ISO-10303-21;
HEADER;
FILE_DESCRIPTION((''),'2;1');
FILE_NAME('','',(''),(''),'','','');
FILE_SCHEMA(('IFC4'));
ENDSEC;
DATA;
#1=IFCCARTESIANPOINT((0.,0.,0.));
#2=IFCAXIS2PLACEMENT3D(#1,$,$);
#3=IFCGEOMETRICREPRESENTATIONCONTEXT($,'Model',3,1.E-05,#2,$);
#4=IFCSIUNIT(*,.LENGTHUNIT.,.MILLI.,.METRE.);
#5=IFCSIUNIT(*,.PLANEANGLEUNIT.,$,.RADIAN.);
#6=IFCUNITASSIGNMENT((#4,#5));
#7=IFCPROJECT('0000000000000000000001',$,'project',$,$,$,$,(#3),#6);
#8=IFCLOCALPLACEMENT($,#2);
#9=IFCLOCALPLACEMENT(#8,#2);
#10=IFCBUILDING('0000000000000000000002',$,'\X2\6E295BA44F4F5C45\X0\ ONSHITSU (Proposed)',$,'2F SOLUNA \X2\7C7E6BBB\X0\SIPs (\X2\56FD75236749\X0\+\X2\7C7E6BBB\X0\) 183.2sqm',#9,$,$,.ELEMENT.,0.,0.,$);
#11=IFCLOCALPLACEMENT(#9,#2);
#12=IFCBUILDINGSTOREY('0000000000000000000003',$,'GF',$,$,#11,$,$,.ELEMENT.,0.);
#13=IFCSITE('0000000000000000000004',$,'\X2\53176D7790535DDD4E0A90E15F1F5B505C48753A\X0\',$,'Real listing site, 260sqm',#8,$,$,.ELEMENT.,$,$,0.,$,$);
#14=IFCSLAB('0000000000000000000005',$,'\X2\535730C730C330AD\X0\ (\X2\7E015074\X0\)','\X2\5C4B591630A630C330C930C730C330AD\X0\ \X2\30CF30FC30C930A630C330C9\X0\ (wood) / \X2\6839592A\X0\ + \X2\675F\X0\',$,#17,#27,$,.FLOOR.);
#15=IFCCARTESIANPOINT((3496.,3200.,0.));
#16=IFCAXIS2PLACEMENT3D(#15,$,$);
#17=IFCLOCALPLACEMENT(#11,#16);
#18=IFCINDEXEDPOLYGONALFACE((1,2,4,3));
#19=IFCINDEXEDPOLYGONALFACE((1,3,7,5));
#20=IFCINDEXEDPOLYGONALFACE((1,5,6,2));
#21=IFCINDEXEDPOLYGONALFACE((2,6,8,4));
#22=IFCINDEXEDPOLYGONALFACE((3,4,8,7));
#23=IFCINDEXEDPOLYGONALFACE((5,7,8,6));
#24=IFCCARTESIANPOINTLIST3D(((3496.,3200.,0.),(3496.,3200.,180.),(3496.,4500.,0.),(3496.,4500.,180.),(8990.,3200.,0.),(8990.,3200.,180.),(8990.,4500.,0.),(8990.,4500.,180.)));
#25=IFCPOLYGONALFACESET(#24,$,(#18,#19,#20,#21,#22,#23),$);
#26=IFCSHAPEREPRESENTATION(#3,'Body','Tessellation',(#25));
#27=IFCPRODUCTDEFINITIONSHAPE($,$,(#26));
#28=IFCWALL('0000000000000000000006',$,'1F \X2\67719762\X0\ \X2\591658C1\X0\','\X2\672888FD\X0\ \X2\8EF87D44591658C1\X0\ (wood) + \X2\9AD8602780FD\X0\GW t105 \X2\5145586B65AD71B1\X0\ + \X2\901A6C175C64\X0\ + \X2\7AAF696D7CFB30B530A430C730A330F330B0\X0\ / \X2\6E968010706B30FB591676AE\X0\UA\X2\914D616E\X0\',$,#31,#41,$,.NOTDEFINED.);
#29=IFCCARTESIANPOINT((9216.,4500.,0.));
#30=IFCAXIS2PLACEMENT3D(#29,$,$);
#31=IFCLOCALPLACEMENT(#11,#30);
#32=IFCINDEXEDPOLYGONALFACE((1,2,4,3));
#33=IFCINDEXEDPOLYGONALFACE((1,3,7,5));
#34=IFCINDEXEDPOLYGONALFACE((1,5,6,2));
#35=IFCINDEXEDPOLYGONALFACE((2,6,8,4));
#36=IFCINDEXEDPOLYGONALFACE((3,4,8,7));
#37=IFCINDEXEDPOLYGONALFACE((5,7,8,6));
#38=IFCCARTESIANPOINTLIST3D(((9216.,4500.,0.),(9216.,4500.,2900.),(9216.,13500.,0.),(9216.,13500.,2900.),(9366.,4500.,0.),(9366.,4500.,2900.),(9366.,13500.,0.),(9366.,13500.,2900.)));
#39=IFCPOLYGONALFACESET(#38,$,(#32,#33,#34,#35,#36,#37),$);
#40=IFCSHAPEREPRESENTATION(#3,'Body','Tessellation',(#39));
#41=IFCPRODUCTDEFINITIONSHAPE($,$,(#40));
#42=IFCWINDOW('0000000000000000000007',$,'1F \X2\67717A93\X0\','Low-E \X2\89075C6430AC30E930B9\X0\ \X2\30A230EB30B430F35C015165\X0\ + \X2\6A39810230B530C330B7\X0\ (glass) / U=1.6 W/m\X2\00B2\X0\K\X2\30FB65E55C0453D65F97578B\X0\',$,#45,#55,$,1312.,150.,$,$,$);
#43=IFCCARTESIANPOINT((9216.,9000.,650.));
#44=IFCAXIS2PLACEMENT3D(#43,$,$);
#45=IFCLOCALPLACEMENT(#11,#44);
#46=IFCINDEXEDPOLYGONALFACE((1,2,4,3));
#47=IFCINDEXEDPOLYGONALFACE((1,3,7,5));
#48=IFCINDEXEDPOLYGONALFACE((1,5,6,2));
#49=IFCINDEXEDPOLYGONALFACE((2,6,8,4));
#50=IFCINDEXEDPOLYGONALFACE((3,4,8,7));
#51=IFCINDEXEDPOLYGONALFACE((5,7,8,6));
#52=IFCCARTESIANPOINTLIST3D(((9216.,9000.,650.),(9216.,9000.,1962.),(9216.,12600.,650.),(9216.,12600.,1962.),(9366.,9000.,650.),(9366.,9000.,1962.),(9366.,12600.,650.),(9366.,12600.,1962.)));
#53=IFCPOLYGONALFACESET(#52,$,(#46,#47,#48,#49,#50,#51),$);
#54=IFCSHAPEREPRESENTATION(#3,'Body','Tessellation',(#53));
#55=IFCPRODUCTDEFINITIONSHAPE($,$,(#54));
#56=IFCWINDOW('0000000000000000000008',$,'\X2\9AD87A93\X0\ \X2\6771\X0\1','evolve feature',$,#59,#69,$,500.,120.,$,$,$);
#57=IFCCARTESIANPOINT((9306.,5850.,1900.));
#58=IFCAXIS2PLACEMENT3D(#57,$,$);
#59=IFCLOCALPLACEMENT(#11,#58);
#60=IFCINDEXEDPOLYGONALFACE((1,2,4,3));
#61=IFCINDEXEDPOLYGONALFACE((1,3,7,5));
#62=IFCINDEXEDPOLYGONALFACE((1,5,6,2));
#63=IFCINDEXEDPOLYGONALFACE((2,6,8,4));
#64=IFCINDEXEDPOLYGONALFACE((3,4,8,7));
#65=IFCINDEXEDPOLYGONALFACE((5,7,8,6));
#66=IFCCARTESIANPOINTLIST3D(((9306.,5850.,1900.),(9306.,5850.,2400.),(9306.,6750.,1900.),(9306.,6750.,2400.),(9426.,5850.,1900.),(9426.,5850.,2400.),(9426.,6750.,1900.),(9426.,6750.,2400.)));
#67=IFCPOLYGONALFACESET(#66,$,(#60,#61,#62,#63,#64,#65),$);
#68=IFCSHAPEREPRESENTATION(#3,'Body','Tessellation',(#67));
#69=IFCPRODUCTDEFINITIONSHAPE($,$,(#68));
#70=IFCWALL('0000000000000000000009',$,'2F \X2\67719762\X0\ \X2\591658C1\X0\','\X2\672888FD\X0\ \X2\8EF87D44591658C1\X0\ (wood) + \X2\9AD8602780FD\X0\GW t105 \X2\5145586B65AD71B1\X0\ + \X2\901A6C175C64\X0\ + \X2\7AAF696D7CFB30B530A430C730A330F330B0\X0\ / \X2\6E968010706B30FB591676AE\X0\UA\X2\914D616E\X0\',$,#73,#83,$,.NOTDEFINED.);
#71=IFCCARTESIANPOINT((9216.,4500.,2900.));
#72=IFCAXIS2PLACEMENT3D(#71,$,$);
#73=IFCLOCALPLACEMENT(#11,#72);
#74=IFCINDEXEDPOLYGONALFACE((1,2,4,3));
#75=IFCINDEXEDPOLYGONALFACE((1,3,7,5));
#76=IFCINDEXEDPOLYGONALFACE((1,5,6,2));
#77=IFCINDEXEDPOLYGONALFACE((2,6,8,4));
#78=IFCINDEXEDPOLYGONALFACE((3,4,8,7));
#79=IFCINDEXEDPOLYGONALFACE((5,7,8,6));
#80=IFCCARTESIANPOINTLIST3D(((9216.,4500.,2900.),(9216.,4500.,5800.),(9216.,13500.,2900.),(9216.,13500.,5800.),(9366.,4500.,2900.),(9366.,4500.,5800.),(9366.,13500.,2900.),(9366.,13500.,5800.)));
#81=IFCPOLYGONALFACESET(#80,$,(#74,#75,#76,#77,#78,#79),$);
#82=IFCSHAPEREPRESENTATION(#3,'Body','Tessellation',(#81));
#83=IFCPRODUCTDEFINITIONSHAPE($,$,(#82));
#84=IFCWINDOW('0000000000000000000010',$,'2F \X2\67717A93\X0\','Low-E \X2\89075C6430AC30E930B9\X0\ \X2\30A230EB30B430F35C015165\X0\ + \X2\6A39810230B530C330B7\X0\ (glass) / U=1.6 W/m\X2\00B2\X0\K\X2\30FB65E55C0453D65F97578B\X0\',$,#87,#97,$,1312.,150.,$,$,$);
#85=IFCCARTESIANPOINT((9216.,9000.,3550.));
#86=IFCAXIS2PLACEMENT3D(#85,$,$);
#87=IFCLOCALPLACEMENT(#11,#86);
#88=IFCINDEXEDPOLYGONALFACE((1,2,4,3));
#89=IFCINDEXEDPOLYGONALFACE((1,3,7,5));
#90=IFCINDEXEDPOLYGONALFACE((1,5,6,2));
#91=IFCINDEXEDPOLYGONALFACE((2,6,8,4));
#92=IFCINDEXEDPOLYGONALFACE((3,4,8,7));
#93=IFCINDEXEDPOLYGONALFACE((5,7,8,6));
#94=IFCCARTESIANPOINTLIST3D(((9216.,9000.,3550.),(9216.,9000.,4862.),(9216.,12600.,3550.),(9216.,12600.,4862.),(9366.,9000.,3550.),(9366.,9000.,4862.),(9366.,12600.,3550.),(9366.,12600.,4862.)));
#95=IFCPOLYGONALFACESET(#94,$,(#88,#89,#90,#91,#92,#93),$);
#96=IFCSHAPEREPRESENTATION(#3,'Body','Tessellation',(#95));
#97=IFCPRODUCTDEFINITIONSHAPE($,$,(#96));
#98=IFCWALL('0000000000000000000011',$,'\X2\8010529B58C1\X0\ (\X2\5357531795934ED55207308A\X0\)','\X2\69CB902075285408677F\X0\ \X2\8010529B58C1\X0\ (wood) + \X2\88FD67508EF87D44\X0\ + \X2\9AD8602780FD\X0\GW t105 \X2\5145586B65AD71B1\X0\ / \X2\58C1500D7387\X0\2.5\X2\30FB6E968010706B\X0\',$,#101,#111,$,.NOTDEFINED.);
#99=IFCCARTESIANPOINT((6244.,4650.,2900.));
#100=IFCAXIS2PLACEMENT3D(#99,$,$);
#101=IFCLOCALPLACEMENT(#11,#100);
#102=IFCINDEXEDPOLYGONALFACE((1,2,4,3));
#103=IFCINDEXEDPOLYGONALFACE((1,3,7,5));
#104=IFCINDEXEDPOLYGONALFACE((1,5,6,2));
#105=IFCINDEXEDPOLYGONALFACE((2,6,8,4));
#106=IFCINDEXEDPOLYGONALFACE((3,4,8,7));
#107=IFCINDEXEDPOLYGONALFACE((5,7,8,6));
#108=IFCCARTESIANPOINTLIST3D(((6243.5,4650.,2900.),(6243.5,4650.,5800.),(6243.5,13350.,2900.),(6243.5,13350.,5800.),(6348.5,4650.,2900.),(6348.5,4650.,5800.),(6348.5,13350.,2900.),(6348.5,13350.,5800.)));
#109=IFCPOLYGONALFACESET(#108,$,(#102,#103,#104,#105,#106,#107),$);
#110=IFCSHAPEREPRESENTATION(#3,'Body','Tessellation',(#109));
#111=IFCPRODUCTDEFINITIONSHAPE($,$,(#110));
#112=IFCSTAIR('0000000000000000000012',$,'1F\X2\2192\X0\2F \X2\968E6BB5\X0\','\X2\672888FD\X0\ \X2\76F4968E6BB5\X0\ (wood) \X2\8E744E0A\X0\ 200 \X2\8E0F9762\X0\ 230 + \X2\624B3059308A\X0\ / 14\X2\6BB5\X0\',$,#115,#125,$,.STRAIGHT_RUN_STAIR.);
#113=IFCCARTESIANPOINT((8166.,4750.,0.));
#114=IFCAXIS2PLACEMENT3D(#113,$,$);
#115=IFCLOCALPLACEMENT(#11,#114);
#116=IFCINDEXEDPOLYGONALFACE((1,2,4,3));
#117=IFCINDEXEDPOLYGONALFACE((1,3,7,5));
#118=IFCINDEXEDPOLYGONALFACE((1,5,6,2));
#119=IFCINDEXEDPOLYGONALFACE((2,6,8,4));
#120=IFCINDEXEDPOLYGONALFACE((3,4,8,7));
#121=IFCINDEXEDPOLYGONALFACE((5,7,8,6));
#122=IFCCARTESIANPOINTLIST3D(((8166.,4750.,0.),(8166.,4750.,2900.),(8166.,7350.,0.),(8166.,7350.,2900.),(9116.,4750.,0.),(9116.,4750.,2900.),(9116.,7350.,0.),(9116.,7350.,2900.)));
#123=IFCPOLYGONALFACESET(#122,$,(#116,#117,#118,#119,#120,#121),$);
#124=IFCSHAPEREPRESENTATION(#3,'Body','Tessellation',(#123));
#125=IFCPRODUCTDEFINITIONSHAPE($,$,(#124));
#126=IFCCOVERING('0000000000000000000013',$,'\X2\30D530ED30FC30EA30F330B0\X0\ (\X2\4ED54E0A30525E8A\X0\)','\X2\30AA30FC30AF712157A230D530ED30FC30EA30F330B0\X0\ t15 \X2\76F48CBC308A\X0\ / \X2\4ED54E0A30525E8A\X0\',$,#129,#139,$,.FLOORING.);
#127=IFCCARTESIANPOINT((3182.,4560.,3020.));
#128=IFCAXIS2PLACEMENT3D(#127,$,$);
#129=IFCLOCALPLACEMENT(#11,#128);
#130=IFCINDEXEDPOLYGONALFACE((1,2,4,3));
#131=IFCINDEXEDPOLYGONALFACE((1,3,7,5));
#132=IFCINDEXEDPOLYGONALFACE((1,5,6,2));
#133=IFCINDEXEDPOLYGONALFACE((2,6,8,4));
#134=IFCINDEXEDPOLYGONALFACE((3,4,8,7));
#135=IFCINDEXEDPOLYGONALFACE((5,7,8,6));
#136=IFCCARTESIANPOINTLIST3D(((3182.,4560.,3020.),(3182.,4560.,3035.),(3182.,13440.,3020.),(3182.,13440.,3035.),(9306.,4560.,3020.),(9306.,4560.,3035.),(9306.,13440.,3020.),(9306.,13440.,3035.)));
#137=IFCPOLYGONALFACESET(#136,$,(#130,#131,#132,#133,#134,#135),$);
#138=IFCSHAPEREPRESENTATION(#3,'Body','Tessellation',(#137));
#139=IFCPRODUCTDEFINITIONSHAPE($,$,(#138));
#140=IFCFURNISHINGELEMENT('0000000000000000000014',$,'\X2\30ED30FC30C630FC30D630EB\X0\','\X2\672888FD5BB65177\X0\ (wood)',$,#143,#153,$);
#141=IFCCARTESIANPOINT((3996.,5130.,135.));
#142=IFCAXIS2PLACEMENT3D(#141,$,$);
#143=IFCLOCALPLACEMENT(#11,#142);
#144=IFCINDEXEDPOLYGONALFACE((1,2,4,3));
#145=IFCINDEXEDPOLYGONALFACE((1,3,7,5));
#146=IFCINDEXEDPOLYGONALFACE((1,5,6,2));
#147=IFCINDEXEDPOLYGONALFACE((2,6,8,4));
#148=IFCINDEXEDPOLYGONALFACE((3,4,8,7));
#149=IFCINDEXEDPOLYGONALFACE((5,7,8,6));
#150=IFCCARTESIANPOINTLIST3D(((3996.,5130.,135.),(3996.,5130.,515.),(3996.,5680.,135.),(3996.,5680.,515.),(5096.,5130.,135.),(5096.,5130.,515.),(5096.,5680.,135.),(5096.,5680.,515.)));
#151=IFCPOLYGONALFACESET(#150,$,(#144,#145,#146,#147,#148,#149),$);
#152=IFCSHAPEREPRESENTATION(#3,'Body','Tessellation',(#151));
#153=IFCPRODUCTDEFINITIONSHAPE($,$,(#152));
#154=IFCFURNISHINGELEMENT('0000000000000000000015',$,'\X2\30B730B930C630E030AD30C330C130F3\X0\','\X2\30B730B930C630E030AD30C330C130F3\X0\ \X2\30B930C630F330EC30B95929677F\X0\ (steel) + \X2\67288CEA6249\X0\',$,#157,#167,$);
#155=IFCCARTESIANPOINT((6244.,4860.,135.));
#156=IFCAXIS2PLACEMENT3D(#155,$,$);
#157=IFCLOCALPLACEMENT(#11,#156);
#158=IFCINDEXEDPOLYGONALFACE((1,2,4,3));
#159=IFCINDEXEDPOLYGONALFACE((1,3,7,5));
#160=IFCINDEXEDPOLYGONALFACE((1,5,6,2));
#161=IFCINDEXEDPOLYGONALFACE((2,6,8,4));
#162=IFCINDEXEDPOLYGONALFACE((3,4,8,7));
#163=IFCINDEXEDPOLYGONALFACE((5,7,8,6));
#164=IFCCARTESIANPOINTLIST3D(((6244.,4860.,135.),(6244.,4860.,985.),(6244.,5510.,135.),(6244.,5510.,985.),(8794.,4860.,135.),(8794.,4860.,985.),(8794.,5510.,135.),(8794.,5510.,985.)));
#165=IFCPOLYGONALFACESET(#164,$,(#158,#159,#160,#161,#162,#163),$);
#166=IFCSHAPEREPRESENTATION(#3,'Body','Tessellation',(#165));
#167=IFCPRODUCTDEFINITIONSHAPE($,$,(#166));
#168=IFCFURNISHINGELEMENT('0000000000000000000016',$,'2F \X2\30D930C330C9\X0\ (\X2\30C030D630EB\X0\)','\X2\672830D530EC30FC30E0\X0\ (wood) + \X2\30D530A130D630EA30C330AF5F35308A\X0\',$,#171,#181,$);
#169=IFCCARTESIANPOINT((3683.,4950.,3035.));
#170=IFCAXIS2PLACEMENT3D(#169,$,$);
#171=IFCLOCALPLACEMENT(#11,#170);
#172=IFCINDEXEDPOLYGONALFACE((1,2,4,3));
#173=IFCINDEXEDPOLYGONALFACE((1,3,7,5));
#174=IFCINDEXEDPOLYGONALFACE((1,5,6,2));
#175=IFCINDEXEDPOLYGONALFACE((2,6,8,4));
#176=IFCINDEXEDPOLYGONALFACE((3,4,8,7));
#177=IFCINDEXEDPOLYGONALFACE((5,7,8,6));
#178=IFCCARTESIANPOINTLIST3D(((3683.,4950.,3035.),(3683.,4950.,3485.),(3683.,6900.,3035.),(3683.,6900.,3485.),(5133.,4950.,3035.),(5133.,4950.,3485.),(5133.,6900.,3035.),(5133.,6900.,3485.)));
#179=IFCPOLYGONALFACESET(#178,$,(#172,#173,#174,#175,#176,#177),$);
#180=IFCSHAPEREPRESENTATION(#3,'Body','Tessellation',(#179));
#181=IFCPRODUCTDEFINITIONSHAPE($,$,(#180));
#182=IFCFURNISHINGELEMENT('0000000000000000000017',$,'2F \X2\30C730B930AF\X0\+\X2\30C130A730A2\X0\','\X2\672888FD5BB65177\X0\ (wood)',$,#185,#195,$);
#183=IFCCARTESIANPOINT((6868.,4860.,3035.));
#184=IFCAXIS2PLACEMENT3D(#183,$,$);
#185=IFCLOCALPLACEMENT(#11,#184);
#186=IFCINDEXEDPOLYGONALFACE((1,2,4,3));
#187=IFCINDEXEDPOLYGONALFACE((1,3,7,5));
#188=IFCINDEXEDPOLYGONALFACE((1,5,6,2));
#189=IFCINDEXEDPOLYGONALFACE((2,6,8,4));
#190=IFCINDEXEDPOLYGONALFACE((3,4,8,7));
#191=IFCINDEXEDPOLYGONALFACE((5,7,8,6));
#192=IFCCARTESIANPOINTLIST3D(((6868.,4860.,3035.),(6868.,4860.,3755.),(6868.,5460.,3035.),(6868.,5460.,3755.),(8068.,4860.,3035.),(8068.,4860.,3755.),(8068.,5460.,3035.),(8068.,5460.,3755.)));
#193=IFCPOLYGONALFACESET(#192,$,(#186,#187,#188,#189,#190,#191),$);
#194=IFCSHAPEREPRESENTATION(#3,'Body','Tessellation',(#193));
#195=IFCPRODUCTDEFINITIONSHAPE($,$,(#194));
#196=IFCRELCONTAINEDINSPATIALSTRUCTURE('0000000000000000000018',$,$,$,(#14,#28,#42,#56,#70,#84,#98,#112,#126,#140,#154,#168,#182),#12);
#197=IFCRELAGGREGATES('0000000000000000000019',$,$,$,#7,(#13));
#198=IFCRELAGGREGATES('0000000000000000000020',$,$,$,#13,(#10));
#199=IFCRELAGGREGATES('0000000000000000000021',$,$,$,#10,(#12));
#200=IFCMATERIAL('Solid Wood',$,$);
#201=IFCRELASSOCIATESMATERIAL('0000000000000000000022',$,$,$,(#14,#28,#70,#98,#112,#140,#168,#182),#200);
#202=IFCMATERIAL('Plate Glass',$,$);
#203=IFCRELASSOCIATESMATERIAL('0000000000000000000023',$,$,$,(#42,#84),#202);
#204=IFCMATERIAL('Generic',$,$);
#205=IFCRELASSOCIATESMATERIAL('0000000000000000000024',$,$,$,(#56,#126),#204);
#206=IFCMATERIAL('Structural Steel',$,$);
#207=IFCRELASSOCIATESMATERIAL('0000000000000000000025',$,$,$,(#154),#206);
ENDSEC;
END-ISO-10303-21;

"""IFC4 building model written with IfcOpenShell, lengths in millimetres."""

from ifc_helpers import new_model, si_unit, frame, frame_2d, origin, place, context, project, spatial, rectangle, extrude, material, element, fill, save


model = new_model("IFC4")

# Units and contexts
model_context = context("Model", 3, precision=1e-05, world=origin())
ifc_project = project(units=[si_unit("LENGTHUNIT", "METRE", prefix="MILLI"), si_unit("PLANEANGLEUNIT", "RADIAN")], contexts=[model_context])

# Site, building, storey
site_placement = place(None, origin())
site = spatial("IfcSite", under=ifc_project, at=site_placement, Name="北海道川上郡弟子屈町", ObjectType="Real listing site, 260sqm", CompositionType="ELEMENT", RefElevation=0.0)
building_placement = place(site_placement, origin())
building = spatial("IfcBuilding", under=site, at=building_placement, Name="温室住居 ONSHITSU (Proposed)", ObjectType="2F SOLUNA 籾殻SIPs (国産杉+籾殻) 183.2sqm", CompositionType="ELEMENT", ElevationOfRefHeight=0.0, ElevationOfTerrain=0.0)
storey_placement = place(building_placement, origin())
storey = spatial("IfcBuildingStorey", under=building, at=storey_placement, Name="GF", CompositionType="ELEMENT", Elevation=0.0)

# Slab
ifc_material_1 = material(Name="Solid Wood")
slab_placement = place(storey_placement, frame((3496.0, 3200.0, 0.0)))
element("IfcSlab", 1, at=slab_placement, inside=storey, material=ifc_material_1, Name="南デッキ (縁側)", Description="屋外ウッドデッキ ハードウッド (wood) / 根太 + 束", PredefinedType="FLOOR", context=model_context, shape_type="SweptSolid", body=[
    extrude(rectangle(XDim=5494.0, YDim=1300.0, at=frame_2d((2747.0, 650.0))), frame((3496.0, 3200.0, 0.0)), (0.0, 0.0, 1.0), 180.0),
])

# Wall, openings, windows
wall_1_placement = place(storey_placement, frame((9216.0, 4500.0, 0.0)))
wall_1 = element("IfcWall", 2, at=wall_1_placement, inside=storey, material=ifc_material_1, Name="1F 東面 外壁", Description="木製 軸組外壁 (wood) + 高性能GW t105 充填断熱 + 通気層 + 窯業系サイディング / 準耐火・外皮UA配慮", PredefinedType="NOTDEFINED", context=model_context, shape_type="SweptSolid", body=[
    extrude(rectangle(XDim=150.0, YDim=9000.0, at=frame_2d((75.0, 4500.0))), frame((9216.0, 4500.0, 0.0)), (0.0, 0.0, 1.0), 2900.0),
])
opening_1_placement = place(storey_placement, frame((9216.0, 9000.0, 650.0)))
opening_1 = element("IfcOpeningElement", 3, at=opening_1_placement, cuts=wall_1, PredefinedType="NOTDEFINED", context=model_context, shape_type="SweptSolid", body=[
    extrude(rectangle(XDim=150.0, YDim=3600.0, at=frame_2d((75.0, 1800.0))), frame((9216.0, 9000.0, 650.0)), (0.0, 0.0, 1.0), 1312.0),
])
opening_2_placement = place(storey_placement, frame((9306.0, 5850.0, 1900.0)))
opening_2 = element("IfcOpeningElement", 4, at=opening_2_placement, cuts=wall_1, PredefinedType="NOTDEFINED", context=model_context, shape_type="SweptSolid", body=[
    extrude(rectangle(XDim=120.0, YDim=900.0, at=frame_2d((60.0, 450.0))), frame((9306.0, 5850.0, 1900.0)), (0.0, 0.0, 1.0), 500.0),
])
ifc_material_2 = material(Name="Plate Glass")
window_1_placement = place(storey_placement, frame((9216.0, 9000.0, 650.0)))
window_1 = element("IfcWindow", 5, at=window_1_placement, inside=storey, material=ifc_material_2, Name="1F 東窓", Description="Low-E 複層ガラス アルゴン封入 + 樹脂サッシ (glass) / U=1.6 W/m²K・日射取得型", OverallHeight=1312.0, OverallWidth=150.0, context=model_context, shape_type="SweptSolid", body=[
    extrude(rectangle(XDim=150.0, YDim=3600.0, at=frame_2d((75.0, 1800.0))), frame((9216.0, 9000.0, 650.0)), (0.0, 0.0, 1.0), 1312.0),
])
fill(opening_1, window_1)
ifc_material_3 = material(Name="Generic")
window_2_placement = place(storey_placement, frame((9306.0, 5850.0, 1900.0)))
window_2 = element("IfcWindow", 6, at=window_2_placement, inside=storey, material=ifc_material_3, Name="高窓 東1", Description="evolve feature", OverallHeight=500.0, OverallWidth=120.0, context=model_context, shape_type="SweptSolid", body=[
    extrude(rectangle(XDim=120.0, YDim=900.0, at=frame_2d((60.0, 450.0))), frame((9306.0, 5850.0, 1900.0)), (0.0, 0.0, 1.0), 500.0),
])
fill(opening_2, window_2)

# Wall, opening, window
wall_2_placement = place(storey_placement, frame((9216.0, 4500.0, 2900.0)))
wall_2 = element("IfcWall", 7, at=wall_2_placement, inside=storey, material=ifc_material_1, Name="2F 東面 外壁", Description="木製 軸組外壁 (wood) + 高性能GW t105 充填断熱 + 通気層 + 窯業系サイディング / 準耐火・外皮UA配慮", PredefinedType="NOTDEFINED", context=model_context, shape_type="SweptSolid", body=[
    extrude(rectangle(XDim=150.0, YDim=9000.0, at=frame_2d((75.0, 4500.0))), frame((9216.0, 4500.0, 2900.0)), (0.0, 0.0, 1.0), 2900.0),
])
opening_3_placement = place(storey_placement, frame((9216.0, 9000.0, 3550.0)))
opening_3 = element("IfcOpeningElement", 8, at=opening_3_placement, cuts=wall_2, PredefinedType="NOTDEFINED", context=model_context, shape_type="SweptSolid", body=[
    extrude(rectangle(XDim=150.0, YDim=3600.0, at=frame_2d((75.0, 1800.0))), frame((9216.0, 9000.0, 3550.0)), (0.0, 0.0, 1.0), 1312.0),
])
window_3_placement = place(storey_placement, frame((9216.0, 9000.0, 3550.0)))
window_3 = element("IfcWindow", 9, at=window_3_placement, inside=storey, material=ifc_material_2, Name="2F 東窓", Description="Low-E 複層ガラス アルゴン封入 + 樹脂サッシ (glass) / U=1.6 W/m²K・日射取得型", OverallHeight=1312.0, OverallWidth=150.0, context=model_context, shape_type="SweptSolid", body=[
    extrude(rectangle(XDim=150.0, YDim=3600.0, at=frame_2d((75.0, 1800.0))), frame((9216.0, 9000.0, 3550.0)), (0.0, 0.0, 1.0), 1312.0),
])
fill(opening_3, window_3)

# Wall
wall_3_placement = place(storey_placement, frame((6244.0, 4650.0, 2900.0)))
element("IfcWall", 10, at=wall_3_placement, inside=storey, material=ifc_material_1, Name="耐力壁 (南北間仕切り)", Description="構造用合板 耐力壁 (wood) + 製材軸組 + 高性能GW t105 充填断熱 / 壁倍率2.5・準耐火", PredefinedType="NOTDEFINED", context=model_context, shape_type="SweptSolid", body=[
    extrude(rectangle(XDim=105.0, YDim=8700.0, at=frame_2d((52.0, 4350.0))), frame((6244.0, 4650.0, 2900.0)), (0.0, 0.0, 1.0), 2900.0),
])

# Stair
stair_placement = place(storey_placement, frame((8166.0, 4750.0, 0.0)))
element("IfcStair", 11, at=stair_placement, inside=storey, material=ifc_material_1, Name="1F→2F 階段", Description="木製 直階段 (wood) 蹴上 200 踏面 230 + 手すり / 14段", PredefinedType="STRAIGHT_RUN_STAIR", context=model_context, shape_type="SweptSolid", body=[
    extrude(rectangle(XDim=950.0, YDim=2600.0, at=frame_2d((475.0, 1300.0))), frame((8166.0, 4750.0, 0.0)), (0.0, 0.0, 1.0), 2900.0),
])

# Covering
covering_placement = place(storey_placement, frame((3182.0, 4560.0, 3020.0)))
element("IfcCovering", 12, at=covering_placement, inside=storey, material=ifc_material_3, Name="フローリング (仕上げ床)", Description="オーク無垢フローリング t15 直貼り / 仕上げ床", PredefinedType="FLOORING", context=model_context, shape_type="SweptSolid", body=[
    extrude(rectangle(XDim=6124.0, YDim=8880.0, at=frame_2d((3062.0, 4440.0))), frame((3182.0, 4560.0, 3020.0)), (0.0, 0.0, 1.0), 15.0),
])

# Furnishing elements
furnishing_1_placement = place(storey_placement, frame((3996.0, 5130.0, 135.0)))
element("IfcFurnishingElement", 13, at=furnishing_1_placement, inside=storey, material=ifc_material_1, Name="ローテーブル", Description="木製家具 (wood)", context=model_context, shape_type="SweptSolid", body=[
    extrude(rectangle(XDim=1100.0, YDim=550.0, at=frame_2d((550.0, 275.0))), frame((3996.0, 5130.0, 135.0)), (0.0, 0.0, 1.0), 380.0),
])
ifc_material_4 = material(Name="Structural Steel")
furnishing_2_placement = place(storey_placement, frame((6244.0, 4860.0, 135.0)))
element("IfcFurnishingElement", 14, at=furnishing_2_placement, inside=storey, material=ifc_material_4, Name="システムキッチン", Description="システムキッチン ステンレス天板 (steel) + 木質扉", context=model_context, shape_type="SweptSolid", body=[
    extrude(rectangle(XDim=2550.0, YDim=650.0, at=frame_2d((1275.0, 325.0))), frame((6244.0, 4860.0, 135.0)), (0.0, 0.0, 1.0), 850.0),
])
furnishing_3_placement = place(storey_placement, frame((3683.0, 4950.0, 3035.0)))
element("IfcFurnishingElement", 15, at=furnishing_3_placement, inside=storey, material=ifc_material_1, Name="2F ベッド (ダブル)", Description="木フレーム (wood) + ファブリック張り", context=model_context, shape_type="SweptSolid", body=[
    extrude(rectangle(XDim=1450.0, YDim=1950.0, at=frame_2d((725.0, 975.0))), frame((3683.0, 4950.0, 3035.0)), (0.0, 0.0, 1.0), 450.0),
])
furnishing_4_placement = place(storey_placement, frame((6868.0, 4860.0, 3035.0)))
element("IfcFurnishingElement", 16, at=furnishing_4_placement, inside=storey, material=ifc_material_1, Name="2F デスク+チェア", Description="木製家具 (wood)", context=model_context, shape_type="SweptSolid", body=[
    extrude(rectangle(XDim=1200.0, YDim=600.0, at=frame_2d((600.0, 300.0))), frame((6868.0, 4860.0, 3035.0)), (0.0, 0.0, 1.0), 720.0),
])

save(model, "model.ifc")
